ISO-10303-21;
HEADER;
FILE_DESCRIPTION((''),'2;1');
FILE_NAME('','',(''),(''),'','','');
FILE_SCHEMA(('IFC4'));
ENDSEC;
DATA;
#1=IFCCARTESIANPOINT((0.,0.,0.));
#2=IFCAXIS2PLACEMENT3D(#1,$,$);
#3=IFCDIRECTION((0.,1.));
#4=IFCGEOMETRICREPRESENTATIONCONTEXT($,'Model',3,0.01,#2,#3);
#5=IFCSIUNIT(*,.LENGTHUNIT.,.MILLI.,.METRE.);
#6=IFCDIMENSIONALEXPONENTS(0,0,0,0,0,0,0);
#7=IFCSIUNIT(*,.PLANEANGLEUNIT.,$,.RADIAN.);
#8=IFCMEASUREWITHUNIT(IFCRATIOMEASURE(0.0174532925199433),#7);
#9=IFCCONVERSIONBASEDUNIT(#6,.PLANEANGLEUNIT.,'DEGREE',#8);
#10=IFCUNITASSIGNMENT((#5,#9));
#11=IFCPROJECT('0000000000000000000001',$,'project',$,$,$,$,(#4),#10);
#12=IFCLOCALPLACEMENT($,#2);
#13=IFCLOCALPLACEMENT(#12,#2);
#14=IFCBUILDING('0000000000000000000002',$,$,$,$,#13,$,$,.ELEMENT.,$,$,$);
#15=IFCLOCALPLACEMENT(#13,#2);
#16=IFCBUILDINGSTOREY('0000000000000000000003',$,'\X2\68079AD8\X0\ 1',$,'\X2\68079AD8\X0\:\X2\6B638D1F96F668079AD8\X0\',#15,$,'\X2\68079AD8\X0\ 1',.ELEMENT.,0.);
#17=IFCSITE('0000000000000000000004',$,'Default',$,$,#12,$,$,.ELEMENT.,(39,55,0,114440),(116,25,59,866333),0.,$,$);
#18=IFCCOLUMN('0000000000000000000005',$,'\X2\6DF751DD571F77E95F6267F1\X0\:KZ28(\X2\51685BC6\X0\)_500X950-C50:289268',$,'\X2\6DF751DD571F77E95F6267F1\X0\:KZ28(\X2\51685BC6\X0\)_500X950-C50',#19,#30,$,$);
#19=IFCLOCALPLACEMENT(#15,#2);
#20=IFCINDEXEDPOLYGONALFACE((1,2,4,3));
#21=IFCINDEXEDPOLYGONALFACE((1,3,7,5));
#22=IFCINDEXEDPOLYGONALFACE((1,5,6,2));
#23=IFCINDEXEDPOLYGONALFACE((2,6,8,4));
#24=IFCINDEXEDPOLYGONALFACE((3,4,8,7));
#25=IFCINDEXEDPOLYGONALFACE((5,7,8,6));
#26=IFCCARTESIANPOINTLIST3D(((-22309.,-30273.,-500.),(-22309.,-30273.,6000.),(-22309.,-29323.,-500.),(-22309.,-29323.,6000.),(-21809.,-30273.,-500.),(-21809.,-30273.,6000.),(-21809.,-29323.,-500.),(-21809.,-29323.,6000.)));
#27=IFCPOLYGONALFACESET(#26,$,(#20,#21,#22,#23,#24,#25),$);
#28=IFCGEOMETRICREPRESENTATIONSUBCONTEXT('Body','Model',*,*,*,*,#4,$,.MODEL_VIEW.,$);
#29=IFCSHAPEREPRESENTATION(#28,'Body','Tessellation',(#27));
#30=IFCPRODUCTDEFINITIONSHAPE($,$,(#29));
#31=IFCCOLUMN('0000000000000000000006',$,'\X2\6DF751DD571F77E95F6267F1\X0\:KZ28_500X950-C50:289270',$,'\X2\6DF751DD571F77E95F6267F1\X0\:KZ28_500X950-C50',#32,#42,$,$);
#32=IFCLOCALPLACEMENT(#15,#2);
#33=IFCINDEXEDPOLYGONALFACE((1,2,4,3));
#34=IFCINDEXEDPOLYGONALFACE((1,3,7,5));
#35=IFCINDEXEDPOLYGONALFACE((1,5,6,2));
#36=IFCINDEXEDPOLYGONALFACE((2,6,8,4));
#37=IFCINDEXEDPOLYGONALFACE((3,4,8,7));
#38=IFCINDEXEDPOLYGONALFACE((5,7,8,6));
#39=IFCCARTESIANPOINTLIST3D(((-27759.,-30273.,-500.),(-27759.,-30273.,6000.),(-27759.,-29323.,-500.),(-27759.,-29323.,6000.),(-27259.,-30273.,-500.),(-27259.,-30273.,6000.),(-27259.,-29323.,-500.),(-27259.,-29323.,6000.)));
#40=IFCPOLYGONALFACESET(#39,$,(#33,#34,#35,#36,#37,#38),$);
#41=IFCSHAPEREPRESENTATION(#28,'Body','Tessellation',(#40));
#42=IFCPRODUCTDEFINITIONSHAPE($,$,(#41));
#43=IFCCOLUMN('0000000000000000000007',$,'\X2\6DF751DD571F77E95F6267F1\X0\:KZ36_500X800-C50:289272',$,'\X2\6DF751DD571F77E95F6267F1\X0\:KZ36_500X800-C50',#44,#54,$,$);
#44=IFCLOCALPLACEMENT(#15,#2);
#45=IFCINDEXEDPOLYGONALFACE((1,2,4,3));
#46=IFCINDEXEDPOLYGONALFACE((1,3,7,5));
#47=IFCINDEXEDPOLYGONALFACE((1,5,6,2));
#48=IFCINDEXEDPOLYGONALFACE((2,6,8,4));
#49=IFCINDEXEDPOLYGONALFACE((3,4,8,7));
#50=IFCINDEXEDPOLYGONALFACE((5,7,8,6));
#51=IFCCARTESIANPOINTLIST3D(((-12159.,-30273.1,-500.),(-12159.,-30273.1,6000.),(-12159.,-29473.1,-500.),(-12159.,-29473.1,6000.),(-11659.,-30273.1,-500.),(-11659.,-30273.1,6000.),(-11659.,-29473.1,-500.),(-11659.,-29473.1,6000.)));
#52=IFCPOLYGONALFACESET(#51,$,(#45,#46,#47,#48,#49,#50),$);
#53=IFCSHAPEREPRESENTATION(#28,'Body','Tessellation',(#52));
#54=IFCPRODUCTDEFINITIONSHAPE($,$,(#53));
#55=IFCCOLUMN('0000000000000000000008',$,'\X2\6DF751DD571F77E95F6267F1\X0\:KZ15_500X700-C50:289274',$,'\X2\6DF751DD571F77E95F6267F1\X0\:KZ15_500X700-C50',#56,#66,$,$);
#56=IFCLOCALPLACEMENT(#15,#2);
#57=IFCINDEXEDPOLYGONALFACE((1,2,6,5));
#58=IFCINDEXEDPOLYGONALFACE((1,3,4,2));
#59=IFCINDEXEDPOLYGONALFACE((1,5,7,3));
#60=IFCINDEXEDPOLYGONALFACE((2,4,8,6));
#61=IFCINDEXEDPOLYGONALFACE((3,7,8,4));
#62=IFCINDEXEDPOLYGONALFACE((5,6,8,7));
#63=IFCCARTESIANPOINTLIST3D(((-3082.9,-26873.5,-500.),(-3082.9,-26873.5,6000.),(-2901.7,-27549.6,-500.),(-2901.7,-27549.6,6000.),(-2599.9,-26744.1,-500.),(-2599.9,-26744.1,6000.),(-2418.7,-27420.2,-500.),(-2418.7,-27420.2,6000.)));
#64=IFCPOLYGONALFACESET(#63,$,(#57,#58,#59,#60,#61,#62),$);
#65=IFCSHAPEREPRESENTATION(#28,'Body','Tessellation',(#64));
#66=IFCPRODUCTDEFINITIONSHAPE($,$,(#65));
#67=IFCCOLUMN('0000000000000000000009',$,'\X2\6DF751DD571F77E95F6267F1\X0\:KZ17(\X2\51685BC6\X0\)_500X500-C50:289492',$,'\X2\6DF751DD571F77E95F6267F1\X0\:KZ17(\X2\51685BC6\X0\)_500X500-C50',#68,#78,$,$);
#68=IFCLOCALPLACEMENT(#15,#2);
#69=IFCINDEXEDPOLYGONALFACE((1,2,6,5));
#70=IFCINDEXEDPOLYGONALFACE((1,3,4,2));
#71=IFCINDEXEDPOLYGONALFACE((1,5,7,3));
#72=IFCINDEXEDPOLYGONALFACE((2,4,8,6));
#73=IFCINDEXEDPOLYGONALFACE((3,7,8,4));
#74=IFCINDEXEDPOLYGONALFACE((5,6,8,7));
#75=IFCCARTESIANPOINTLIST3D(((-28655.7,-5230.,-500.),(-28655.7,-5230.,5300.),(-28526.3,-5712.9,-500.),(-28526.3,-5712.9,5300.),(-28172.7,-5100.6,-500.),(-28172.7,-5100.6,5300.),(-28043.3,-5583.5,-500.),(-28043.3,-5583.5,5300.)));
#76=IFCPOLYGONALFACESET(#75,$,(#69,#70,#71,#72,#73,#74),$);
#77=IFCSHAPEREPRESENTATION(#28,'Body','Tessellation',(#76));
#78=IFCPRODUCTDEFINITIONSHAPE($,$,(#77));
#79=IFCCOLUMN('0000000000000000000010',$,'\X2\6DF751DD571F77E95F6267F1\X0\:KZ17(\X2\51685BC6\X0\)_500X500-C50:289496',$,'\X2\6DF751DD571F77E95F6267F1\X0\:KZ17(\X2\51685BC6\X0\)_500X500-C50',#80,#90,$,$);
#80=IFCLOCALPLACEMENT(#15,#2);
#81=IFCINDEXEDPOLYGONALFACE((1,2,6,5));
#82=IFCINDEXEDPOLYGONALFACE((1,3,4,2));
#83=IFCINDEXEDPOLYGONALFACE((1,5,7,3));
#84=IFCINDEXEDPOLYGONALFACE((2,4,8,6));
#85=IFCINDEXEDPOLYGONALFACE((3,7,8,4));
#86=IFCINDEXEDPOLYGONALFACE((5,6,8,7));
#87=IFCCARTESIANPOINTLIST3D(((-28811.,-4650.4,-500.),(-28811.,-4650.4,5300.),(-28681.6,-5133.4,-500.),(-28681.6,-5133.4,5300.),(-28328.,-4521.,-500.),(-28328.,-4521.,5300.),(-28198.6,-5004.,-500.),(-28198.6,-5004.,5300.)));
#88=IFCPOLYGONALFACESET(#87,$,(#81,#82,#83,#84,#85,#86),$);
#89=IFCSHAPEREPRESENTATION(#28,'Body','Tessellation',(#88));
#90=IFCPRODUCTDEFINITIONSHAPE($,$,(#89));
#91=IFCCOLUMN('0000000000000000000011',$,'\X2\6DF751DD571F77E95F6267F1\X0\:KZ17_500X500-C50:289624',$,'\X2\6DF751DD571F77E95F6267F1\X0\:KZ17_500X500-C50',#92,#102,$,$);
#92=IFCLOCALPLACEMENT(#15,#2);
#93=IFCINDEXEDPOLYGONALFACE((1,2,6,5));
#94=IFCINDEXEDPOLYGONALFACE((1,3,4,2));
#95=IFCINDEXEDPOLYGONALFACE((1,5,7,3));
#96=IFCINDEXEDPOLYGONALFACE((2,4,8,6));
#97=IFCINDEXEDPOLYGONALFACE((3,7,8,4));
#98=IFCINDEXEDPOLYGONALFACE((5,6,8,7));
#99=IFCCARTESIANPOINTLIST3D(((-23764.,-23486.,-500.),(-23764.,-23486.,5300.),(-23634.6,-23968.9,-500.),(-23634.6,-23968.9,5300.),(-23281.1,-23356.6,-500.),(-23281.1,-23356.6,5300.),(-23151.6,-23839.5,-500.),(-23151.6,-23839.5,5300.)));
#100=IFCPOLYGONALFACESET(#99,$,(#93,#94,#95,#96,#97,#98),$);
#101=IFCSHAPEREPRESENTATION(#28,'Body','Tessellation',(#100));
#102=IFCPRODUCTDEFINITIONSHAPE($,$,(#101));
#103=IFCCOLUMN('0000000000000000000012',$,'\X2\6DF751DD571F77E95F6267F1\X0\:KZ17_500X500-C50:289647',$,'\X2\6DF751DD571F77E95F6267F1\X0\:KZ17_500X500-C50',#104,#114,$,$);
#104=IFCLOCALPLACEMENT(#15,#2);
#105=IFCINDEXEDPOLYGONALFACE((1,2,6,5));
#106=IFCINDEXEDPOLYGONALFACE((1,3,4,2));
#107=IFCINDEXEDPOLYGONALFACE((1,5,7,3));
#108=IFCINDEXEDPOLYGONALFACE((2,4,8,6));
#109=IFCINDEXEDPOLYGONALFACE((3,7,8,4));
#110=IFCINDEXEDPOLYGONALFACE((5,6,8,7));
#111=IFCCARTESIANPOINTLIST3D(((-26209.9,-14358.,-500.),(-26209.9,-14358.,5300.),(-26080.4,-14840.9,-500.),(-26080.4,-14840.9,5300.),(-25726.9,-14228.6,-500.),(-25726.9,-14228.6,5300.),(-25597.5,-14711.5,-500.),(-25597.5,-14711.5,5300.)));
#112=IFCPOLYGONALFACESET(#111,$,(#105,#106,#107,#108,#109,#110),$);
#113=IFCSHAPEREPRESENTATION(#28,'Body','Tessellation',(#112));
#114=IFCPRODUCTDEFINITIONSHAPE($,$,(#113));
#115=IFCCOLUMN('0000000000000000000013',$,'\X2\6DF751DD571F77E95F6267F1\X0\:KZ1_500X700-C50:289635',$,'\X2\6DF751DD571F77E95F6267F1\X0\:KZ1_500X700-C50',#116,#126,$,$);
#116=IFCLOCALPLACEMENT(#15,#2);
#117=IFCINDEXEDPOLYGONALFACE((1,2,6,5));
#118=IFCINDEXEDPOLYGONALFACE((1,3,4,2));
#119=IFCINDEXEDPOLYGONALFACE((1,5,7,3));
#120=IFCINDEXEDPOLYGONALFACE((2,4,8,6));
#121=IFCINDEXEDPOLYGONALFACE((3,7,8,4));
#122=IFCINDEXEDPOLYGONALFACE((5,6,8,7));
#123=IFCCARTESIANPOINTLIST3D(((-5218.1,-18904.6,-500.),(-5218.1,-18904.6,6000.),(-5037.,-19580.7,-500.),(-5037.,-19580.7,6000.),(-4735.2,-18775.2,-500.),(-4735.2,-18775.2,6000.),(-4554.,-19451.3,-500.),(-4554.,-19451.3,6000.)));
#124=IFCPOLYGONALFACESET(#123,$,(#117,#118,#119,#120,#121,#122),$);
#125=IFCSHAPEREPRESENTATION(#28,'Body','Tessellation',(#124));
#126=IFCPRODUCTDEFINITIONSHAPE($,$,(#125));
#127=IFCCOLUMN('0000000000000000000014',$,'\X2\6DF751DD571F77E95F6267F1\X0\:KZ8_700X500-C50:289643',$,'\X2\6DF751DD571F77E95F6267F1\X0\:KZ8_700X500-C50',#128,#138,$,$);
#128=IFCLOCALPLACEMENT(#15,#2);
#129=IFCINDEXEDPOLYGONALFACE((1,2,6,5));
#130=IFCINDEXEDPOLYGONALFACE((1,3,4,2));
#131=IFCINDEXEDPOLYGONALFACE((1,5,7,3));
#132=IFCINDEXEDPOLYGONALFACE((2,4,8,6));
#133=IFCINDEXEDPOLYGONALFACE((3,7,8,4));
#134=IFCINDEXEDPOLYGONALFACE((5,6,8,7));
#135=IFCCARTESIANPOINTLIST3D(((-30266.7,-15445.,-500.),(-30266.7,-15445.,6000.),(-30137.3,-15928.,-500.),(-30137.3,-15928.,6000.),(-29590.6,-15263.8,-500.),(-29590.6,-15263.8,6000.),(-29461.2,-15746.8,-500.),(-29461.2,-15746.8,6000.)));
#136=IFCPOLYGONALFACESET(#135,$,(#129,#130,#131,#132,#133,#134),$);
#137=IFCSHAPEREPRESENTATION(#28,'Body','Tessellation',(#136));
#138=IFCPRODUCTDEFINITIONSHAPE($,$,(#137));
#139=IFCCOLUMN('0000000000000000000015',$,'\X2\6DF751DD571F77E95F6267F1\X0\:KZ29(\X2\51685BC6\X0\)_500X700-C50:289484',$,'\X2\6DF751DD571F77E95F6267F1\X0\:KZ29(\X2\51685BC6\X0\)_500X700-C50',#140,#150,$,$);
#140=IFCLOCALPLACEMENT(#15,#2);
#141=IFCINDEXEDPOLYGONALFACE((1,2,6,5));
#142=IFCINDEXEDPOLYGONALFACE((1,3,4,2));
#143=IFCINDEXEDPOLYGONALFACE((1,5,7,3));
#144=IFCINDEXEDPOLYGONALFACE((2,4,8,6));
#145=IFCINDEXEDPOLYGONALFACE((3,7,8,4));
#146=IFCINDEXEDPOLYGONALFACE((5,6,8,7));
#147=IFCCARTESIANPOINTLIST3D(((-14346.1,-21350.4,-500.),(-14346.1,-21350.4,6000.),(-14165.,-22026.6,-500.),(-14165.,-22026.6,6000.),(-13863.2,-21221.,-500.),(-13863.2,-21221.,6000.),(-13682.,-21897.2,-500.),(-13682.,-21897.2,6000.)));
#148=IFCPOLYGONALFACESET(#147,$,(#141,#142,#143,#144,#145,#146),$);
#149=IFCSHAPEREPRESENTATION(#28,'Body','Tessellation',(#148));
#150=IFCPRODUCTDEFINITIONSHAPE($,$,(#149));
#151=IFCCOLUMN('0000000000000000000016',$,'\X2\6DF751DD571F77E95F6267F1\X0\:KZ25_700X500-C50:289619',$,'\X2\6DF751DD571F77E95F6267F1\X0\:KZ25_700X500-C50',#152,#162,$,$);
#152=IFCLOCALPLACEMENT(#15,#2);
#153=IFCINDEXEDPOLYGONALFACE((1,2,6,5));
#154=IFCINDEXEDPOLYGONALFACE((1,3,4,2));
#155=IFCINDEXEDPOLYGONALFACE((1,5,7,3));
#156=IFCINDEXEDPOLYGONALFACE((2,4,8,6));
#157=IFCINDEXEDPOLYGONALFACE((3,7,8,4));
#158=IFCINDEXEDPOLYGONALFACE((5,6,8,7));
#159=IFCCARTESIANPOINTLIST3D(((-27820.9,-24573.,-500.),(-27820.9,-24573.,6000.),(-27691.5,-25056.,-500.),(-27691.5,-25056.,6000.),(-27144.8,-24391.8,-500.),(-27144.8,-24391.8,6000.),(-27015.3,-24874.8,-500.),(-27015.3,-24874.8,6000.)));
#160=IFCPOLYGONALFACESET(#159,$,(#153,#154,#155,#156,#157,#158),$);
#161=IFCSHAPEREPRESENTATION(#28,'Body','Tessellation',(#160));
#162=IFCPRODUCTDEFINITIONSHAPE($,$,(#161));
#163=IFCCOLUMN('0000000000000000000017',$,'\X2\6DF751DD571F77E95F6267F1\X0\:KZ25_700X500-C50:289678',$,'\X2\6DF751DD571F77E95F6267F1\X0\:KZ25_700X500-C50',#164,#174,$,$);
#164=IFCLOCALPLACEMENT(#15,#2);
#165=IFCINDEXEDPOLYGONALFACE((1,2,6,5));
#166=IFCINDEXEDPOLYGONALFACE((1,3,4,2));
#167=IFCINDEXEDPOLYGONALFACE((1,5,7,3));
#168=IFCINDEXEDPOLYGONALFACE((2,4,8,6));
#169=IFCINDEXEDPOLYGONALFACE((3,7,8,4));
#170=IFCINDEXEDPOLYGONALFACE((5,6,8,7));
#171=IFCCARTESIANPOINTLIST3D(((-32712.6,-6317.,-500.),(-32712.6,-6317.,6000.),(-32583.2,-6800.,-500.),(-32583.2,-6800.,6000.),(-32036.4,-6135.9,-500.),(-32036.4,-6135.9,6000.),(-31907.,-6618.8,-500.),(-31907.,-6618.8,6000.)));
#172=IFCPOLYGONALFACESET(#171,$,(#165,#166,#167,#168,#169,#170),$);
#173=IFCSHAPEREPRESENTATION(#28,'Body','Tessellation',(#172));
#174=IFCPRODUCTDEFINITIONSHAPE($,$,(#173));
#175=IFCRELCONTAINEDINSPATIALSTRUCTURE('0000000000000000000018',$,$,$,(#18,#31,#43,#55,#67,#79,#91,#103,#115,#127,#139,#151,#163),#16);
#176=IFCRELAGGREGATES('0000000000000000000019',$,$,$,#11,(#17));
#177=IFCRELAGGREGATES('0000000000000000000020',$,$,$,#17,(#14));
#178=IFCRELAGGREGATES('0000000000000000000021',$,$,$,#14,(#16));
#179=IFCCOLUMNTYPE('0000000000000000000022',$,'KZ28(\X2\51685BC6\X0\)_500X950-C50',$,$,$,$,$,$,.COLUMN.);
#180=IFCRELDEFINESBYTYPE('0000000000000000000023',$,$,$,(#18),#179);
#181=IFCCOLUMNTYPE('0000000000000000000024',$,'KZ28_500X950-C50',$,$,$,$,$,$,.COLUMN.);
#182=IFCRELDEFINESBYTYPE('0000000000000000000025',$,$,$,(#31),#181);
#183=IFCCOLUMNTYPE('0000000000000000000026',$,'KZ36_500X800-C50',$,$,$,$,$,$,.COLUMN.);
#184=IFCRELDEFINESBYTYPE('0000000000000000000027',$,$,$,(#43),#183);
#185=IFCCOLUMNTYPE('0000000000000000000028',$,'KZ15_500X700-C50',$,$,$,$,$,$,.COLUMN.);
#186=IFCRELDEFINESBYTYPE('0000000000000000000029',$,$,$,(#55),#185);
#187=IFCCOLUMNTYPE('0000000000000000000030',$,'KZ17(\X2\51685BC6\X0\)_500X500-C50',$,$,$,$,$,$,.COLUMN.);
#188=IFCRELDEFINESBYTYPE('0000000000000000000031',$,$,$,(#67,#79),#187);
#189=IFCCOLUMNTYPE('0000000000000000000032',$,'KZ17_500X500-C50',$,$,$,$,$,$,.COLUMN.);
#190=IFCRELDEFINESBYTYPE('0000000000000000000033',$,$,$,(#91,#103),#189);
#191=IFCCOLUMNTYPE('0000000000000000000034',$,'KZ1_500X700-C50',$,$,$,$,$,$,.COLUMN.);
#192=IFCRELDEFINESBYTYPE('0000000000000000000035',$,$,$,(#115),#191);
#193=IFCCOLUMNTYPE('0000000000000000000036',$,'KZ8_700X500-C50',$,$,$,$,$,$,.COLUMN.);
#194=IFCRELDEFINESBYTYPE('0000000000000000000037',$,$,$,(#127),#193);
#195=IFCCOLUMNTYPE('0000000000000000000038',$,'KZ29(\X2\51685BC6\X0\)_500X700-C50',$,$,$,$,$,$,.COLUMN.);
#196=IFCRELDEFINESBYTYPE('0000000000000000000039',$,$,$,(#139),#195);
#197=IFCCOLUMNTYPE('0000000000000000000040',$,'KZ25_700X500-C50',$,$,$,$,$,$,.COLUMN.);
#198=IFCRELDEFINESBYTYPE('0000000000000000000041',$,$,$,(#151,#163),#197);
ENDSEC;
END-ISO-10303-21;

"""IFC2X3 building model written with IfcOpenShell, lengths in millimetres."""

from ifc_helpers import new_model, entity, si_unit, converted_unit, direction, frame, origin, origin_2d_with_axis, place, context, subcontext, project, spatial, rectangle, extrude, source, transform, mapped, type_object, type_shapes, element, save


model = new_model("IFC2X3")

# Units and contexts
model_context = context("Model", 3, precision=0.01, world=origin(), true_north=direction((0.0, 1.0)))
body_context = subcontext(model_context, "Body", "Model", "MODEL_VIEW")
ifc_project = project(units=[si_unit("LENGTHUNIT", "METRE", prefix="MILLI"), converted_unit("PLANEANGLEUNIT", "DEGREE", entity("IfcRatioMeasure", 0.0174532925199433), si_unit("PLANEANGLEUNIT", "RADIAN"), dimensions=[0, 0, 0, 0, 0, 0, 0])], contexts=[model_context])

# Site, building, storey
site_placement = place(None, origin())
site = spatial("IfcSite", under=ifc_project, at=site_placement, Name="Default", CompositionType="ELEMENT", RefLatitude=(39, 55, 0, 114440), RefLongitude=(116, 25, 59, 866333), RefElevation=0.0)
building_placement = place(site_placement, origin())
building = spatial("IfcBuilding", under=site, at=building_placement, CompositionType="ELEMENT")
storey_placement = place(building_placement, origin())
storey = spatial("IfcBuildingStorey", under=building, at=storey_placement, Name="标高 1", ObjectType="标高:正负零标高", LongName="标高 1", CompositionType="ELEMENT", Elevation=0.0)

# Columns
column_type_1 = type_object("IfcColumnType", Name="KZ28(全密)_500X950-C50", PredefinedType="COLUMN")
shared_shape_1 = source(origin(), body_context, "Body", "SweptSolid", [
    extrude(rectangle(XDim=950.0, YDim=500.0, at=origin_2d_with_axis()), frame((0.0, 0.0, -500.0), z_axis=(0.0, 0.0, 1.0), x_axis=(0.0, -1.0, 0.0)), (0.0, 0.0, 1.0), 6500.0),
])
type_shapes(column_type_1, [shared_shape_1])
column_1_placement = place(building_placement, frame((-22059.0, -29798.0, 0.0)))
element("IfcColumn", 1, at=column_1_placement, inside=storey, type_object=column_type_1, Name="混凝土矩形柱:KZ28(全密)_500X950-C50:289268", ObjectType="混凝土矩形柱:KZ28(全密)_500X950-C50", context=body_context, shape_type="MappedRepresentation", body=[
    mapped(shared_shape_1, transform((0.0, 0.0, 0.0), scale=1.0)),
])
column_type_2 = type_object("IfcColumnType", Name="KZ28_500X950-C50", PredefinedType="COLUMN")
shared_shape_2 = source(origin(), body_context, "Body", "SweptSolid", [
    extrude(rectangle(XDim=950.0, YDim=500.0, at=origin_2d_with_axis()), frame((0.0, 0.0, -500.0), z_axis=(0.0, 0.0, 1.0), x_axis=(0.0, -1.0, 0.0)), (0.0, 0.0, 1.0), 6500.0),
])
type_shapes(column_type_2, [shared_shape_2])
column_2_placement = place(building_placement, frame((-27509.0, -29798.0, 0.0)))
element("IfcColumn", 2, at=column_2_placement, inside=storey, type_object=column_type_2, Name="混凝土矩形柱:KZ28_500X950-C50:289270", ObjectType="混凝土矩形柱:KZ28_500X950-C50", context=body_context, shape_type="MappedRepresentation", body=[
    mapped(shared_shape_2, transform((0.0, 0.0, 0.0), scale=1.0)),
])
column_type_3 = type_object("IfcColumnType", Name="KZ36_500X800-C50", PredefinedType="COLUMN")
shared_shape_3 = source(origin(), body_context, "Body", "SweptSolid", [
    extrude(rectangle(XDim=800.0, YDim=500.0, at=origin_2d_with_axis()), frame((0.0, 0.0, -500.0), z_axis=(0.0, 0.0, 1.0), x_axis=(0.0, -1.0, 0.0)), (0.0, 0.0, 1.0), 6500.0),
])
type_shapes(column_type_3, [shared_shape_3])
column_3_placement = place(building_placement, frame((-11909.0, -29873.1, 0.0)))
element("IfcColumn", 3, at=column_3_placement, inside=storey, type_object=column_type_3, Name="混凝土矩形柱:KZ36_500X800-C50:289272", ObjectType="混凝土矩形柱:KZ36_500X800-C50", context=body_context, shape_type="MappedRepresentation", body=[
    mapped(shared_shape_3, transform((0.0, 0.0, 0.0), scale=1.0)),
])
column_type_4 = type_object("IfcColumnType", Name="KZ15_500X700-C50", PredefinedType="COLUMN")
shared_shape_4 = source(origin(), body_context, "Body", "SweptSolid", [
    extrude(rectangle(XDim=700.0, YDim=500.0, at=origin_2d_with_axis()), frame((0.0, 0.0, -500.0), z_axis=(0.0, 0.0, 1.0), x_axis=(0.0, -1.0, 0.0)), (0.0, 0.0, 1.0), 6500.0),
])
type_shapes(column_type_4, [shared_shape_4])
column_4_placement = place(building_placement, frame((-2750.8, -27146.8, 0.0), z_axis=(0.0, 0.0, 1.0), x_axis=(0.965926, 0.258819, 0.0)))
element("IfcColumn", 4, at=column_4_placement, inside=storey, type_object=column_type_4, Name="混凝土矩形柱:KZ15_500X700-C50:289274", ObjectType="混凝土矩形柱:KZ15_500X700-C50", context=body_context, shape_type="MappedRepresentation", body=[
    mapped(shared_shape_4, transform((0.0, 0.0, 0.0), scale=1.0)),
])
column_type_5 = type_object("IfcColumnType", Name="KZ17(全密)_500X500-C50", PredefinedType="COLUMN")
shared_shape_5 = source(origin(), body_context, "Body", "SweptSolid", [
    extrude(rectangle(XDim=500.0, YDim=500.0, at=origin_2d_with_axis()), frame((0.0, 0.0, -500.0), z_axis=(0.0, 0.0, 1.0), x_axis=(0.0, -1.0, 0.0)), (0.0, 0.0, 1.0), 5800.0),
])
type_shapes(column_type_5, [shared_shape_5])
for number, where, z_axis, x_axis, name in (
    (5, (-28349.5, -5406.8, 0.0), (0.0, 0.0, 1.0), (0.258819, -0.965926, 0.0), "混凝土矩形柱:KZ17(全密)_500X500-C50:289492"),
    (6, (-28504.8, -4827.2, 0.0), (0.0, 0.0, 1.0), (0.258819, -0.965926, 0.0), "混凝土矩形柱:KZ17(全密)_500X500-C50:289496"),
):
    element("IfcColumn", number, at=place(building_placement, frame(where, z_axis=z_axis, x_axis=x_axis)), inside=storey, type_object=column_type_5, Name=name, ObjectType="混凝土矩形柱:KZ17(全密)_500X500-C50", context=body_context, shape_type="MappedRepresentation", body=[
        mapped(shared_shape_5, transform((0.0, 0.0, 0.0), scale=1.0)),
    ])
column_type_6 = type_object("IfcColumnType", Name="KZ17_500X500-C50", PredefinedType="COLUMN")
shared_shape_6 = source(origin(), body_context, "Body", "SweptSolid", [
    extrude(rectangle(XDim=500.0, YDim=500.0, at=origin_2d_with_axis()), frame((0.0, 0.0, -500.0), z_axis=(0.0, 0.0, 1.0), x_axis=(0.0, -1.0, 0.0)), (0.0, 0.0, 1.0), 5800.0),
])
type_shapes(column_type_6, [shared_shape_6])
for number, where, z_axis, x_axis, name in (
    (7, (-23457.8, -23662.8, 0.0), (0.0, 0.0, 1.0), (0.258819, -0.965926, 0.0), "混凝土矩形柱:KZ17_500X500-C50:289624"),
    (8, (-25903.7, -14534.8, 0.0), (0.0, 0.0, 1.0), (0.258819, -0.965926, 0.0), "混凝土矩形柱:KZ17_500X500-C50:289647"),
):
    element("IfcColumn", number, at=place(building_placement, frame(where, z_axis=z_axis, x_axis=x_axis)), inside=storey, type_object=column_type_6, Name=name, ObjectType="混凝土矩形柱:KZ17_500X500-C50", context=body_context, shape_type="MappedRepresentation", body=[
        mapped(shared_shape_6, transform((0.0, 0.0, 0.0), scale=1.0)),
    ])
column_type_7 = type_object("IfcColumnType", Name="KZ1_500X700-C50", PredefinedType="COLUMN")
shared_shape_7 = source(origin(), body_context, "Body", "SweptSolid", [
    extrude(rectangle(XDim=700.0, YDim=500.0, at=origin_2d_with_axis()), frame((0.0, 0.0, -500.0), z_axis=(0.0, 0.0, 1.0), x_axis=(0.0, -1.0, 0.0)), (0.0, 0.0, 1.0), 6500.0),
])
type_shapes(column_type_7, [shared_shape_7])
column_5_placement = place(building_placement, frame((-4886.1, -19178.0, 0.0), z_axis=(0.0, 0.0, 1.0), x_axis=(0.965926, 0.258819, 0.0)))
element("IfcColumn", 9, at=column_5_placement, inside=storey, type_object=column_type_7, Name="混凝土矩形柱:KZ1_500X700-C50:289635", ObjectType="混凝土矩形柱:KZ1_500X700-C50", context=body_context, shape_type="MappedRepresentation", body=[
    mapped(shared_shape_7, transform((0.0, 0.0, 0.0), scale=1.0)),
])
column_type_8 = type_object("IfcColumnType", Name="KZ8_700X500-C50", PredefinedType="COLUMN")
shared_shape_8 = source(origin(), body_context, "Body", "SweptSolid", [
    extrude(rectangle(XDim=500.0, YDim=700.0, at=origin_2d_with_axis()), frame((0.0, 0.0, -500.0), z_axis=(0.0, 0.0, 1.0), x_axis=(0.0, -1.0, 0.0)), (0.0, 0.0, 1.0), 6500.0),
])
type_shapes(column_type_8, [shared_shape_8])
column_6_placement = place(building_placement, frame((-29864.0, -15595.9, 0.0), z_axis=(0.0, 0.0, 1.0), x_axis=(0.965926, 0.258819, 0.0)))
element("IfcColumn", 10, at=column_6_placement, inside=storey, type_object=column_type_8, Name="混凝土矩形柱:KZ8_700X500-C50:289643", ObjectType="混凝土矩形柱:KZ8_700X500-C50", context=body_context, shape_type="MappedRepresentation", body=[
    mapped(shared_shape_8, transform((0.0, 0.0, 0.0), scale=1.0)),
])
column_type_9 = type_object("IfcColumnType", Name="KZ29(全密)_500X700-C50", PredefinedType="COLUMN")
shared_shape_9 = source(origin(), body_context, "Body", "SweptSolid", [
    extrude(rectangle(XDim=700.0, YDim=500.0, at=origin_2d_with_axis()), frame((0.0, 0.0, -500.0), z_axis=(0.0, 0.0, 1.0), x_axis=(0.0, -1.0, 0.0)), (0.0, 0.0, 1.0), 6500.0),
])
type_shapes(column_type_9, [shared_shape_9])
column_7_placement = place(building_placement, frame((-14014.1, -21623.8, 0.0), z_axis=(0.0, 0.0, 1.0), x_axis=(0.965926, 0.258819, 0.0)))
element("IfcColumn", 11, at=column_7_placement, inside=storey, type_object=column_type_9, Name="混凝土矩形柱:KZ29(全密)_500X700-C50:289484", ObjectType="混凝土矩形柱:KZ29(全密)_500X700-C50", context=body_context, shape_type="MappedRepresentation", body=[
    mapped(shared_shape_9, transform((0.0, 0.0, 0.0), scale=1.0)),
])
column_type_10 = type_object("IfcColumnType", Name="KZ25_700X500-C50", PredefinedType="COLUMN")
shared_shape_10 = source(origin(), body_context, "Body", "SweptSolid", [
    extrude(rectangle(XDim=500.0, YDim=700.0, at=origin_2d_with_axis()), frame((0.0, 0.0, -500.0), z_axis=(0.0, 0.0, 1.0), x_axis=(0.0, -1.0, 0.0)), (0.0, 0.0, 1.0), 6500.0),
])
type_shapes(column_type_10, [shared_shape_10])
for number, where, z_axis, x_axis, name in (
    (12, (-27418.1, -24723.9, 0.0), (0.0, 0.0, 1.0), (0.965926, 0.258819, 0.0), "混凝土矩形柱:KZ25_700X500-C50:289619"),
    (13, (-32309.8, -6467.9, 0.0), (0.0, 0.0, 1.0), (0.965926, 0.258819, 0.0), "混凝土矩形柱:KZ25_700X500-C50:289678"),
):
    element("IfcColumn", number, at=place(building_placement, frame(where, z_axis=z_axis, x_axis=x_axis)), inside=storey, type_object=column_type_10, Name=name, ObjectType="混凝土矩形柱:KZ25_700X500-C50", context=body_context, shape_type="MappedRepresentation", body=[
        mapped(shared_shape_10, transform((0.0, 0.0, 0.0), scale=1.0)),
    ])

save(model, "model.ifc")
